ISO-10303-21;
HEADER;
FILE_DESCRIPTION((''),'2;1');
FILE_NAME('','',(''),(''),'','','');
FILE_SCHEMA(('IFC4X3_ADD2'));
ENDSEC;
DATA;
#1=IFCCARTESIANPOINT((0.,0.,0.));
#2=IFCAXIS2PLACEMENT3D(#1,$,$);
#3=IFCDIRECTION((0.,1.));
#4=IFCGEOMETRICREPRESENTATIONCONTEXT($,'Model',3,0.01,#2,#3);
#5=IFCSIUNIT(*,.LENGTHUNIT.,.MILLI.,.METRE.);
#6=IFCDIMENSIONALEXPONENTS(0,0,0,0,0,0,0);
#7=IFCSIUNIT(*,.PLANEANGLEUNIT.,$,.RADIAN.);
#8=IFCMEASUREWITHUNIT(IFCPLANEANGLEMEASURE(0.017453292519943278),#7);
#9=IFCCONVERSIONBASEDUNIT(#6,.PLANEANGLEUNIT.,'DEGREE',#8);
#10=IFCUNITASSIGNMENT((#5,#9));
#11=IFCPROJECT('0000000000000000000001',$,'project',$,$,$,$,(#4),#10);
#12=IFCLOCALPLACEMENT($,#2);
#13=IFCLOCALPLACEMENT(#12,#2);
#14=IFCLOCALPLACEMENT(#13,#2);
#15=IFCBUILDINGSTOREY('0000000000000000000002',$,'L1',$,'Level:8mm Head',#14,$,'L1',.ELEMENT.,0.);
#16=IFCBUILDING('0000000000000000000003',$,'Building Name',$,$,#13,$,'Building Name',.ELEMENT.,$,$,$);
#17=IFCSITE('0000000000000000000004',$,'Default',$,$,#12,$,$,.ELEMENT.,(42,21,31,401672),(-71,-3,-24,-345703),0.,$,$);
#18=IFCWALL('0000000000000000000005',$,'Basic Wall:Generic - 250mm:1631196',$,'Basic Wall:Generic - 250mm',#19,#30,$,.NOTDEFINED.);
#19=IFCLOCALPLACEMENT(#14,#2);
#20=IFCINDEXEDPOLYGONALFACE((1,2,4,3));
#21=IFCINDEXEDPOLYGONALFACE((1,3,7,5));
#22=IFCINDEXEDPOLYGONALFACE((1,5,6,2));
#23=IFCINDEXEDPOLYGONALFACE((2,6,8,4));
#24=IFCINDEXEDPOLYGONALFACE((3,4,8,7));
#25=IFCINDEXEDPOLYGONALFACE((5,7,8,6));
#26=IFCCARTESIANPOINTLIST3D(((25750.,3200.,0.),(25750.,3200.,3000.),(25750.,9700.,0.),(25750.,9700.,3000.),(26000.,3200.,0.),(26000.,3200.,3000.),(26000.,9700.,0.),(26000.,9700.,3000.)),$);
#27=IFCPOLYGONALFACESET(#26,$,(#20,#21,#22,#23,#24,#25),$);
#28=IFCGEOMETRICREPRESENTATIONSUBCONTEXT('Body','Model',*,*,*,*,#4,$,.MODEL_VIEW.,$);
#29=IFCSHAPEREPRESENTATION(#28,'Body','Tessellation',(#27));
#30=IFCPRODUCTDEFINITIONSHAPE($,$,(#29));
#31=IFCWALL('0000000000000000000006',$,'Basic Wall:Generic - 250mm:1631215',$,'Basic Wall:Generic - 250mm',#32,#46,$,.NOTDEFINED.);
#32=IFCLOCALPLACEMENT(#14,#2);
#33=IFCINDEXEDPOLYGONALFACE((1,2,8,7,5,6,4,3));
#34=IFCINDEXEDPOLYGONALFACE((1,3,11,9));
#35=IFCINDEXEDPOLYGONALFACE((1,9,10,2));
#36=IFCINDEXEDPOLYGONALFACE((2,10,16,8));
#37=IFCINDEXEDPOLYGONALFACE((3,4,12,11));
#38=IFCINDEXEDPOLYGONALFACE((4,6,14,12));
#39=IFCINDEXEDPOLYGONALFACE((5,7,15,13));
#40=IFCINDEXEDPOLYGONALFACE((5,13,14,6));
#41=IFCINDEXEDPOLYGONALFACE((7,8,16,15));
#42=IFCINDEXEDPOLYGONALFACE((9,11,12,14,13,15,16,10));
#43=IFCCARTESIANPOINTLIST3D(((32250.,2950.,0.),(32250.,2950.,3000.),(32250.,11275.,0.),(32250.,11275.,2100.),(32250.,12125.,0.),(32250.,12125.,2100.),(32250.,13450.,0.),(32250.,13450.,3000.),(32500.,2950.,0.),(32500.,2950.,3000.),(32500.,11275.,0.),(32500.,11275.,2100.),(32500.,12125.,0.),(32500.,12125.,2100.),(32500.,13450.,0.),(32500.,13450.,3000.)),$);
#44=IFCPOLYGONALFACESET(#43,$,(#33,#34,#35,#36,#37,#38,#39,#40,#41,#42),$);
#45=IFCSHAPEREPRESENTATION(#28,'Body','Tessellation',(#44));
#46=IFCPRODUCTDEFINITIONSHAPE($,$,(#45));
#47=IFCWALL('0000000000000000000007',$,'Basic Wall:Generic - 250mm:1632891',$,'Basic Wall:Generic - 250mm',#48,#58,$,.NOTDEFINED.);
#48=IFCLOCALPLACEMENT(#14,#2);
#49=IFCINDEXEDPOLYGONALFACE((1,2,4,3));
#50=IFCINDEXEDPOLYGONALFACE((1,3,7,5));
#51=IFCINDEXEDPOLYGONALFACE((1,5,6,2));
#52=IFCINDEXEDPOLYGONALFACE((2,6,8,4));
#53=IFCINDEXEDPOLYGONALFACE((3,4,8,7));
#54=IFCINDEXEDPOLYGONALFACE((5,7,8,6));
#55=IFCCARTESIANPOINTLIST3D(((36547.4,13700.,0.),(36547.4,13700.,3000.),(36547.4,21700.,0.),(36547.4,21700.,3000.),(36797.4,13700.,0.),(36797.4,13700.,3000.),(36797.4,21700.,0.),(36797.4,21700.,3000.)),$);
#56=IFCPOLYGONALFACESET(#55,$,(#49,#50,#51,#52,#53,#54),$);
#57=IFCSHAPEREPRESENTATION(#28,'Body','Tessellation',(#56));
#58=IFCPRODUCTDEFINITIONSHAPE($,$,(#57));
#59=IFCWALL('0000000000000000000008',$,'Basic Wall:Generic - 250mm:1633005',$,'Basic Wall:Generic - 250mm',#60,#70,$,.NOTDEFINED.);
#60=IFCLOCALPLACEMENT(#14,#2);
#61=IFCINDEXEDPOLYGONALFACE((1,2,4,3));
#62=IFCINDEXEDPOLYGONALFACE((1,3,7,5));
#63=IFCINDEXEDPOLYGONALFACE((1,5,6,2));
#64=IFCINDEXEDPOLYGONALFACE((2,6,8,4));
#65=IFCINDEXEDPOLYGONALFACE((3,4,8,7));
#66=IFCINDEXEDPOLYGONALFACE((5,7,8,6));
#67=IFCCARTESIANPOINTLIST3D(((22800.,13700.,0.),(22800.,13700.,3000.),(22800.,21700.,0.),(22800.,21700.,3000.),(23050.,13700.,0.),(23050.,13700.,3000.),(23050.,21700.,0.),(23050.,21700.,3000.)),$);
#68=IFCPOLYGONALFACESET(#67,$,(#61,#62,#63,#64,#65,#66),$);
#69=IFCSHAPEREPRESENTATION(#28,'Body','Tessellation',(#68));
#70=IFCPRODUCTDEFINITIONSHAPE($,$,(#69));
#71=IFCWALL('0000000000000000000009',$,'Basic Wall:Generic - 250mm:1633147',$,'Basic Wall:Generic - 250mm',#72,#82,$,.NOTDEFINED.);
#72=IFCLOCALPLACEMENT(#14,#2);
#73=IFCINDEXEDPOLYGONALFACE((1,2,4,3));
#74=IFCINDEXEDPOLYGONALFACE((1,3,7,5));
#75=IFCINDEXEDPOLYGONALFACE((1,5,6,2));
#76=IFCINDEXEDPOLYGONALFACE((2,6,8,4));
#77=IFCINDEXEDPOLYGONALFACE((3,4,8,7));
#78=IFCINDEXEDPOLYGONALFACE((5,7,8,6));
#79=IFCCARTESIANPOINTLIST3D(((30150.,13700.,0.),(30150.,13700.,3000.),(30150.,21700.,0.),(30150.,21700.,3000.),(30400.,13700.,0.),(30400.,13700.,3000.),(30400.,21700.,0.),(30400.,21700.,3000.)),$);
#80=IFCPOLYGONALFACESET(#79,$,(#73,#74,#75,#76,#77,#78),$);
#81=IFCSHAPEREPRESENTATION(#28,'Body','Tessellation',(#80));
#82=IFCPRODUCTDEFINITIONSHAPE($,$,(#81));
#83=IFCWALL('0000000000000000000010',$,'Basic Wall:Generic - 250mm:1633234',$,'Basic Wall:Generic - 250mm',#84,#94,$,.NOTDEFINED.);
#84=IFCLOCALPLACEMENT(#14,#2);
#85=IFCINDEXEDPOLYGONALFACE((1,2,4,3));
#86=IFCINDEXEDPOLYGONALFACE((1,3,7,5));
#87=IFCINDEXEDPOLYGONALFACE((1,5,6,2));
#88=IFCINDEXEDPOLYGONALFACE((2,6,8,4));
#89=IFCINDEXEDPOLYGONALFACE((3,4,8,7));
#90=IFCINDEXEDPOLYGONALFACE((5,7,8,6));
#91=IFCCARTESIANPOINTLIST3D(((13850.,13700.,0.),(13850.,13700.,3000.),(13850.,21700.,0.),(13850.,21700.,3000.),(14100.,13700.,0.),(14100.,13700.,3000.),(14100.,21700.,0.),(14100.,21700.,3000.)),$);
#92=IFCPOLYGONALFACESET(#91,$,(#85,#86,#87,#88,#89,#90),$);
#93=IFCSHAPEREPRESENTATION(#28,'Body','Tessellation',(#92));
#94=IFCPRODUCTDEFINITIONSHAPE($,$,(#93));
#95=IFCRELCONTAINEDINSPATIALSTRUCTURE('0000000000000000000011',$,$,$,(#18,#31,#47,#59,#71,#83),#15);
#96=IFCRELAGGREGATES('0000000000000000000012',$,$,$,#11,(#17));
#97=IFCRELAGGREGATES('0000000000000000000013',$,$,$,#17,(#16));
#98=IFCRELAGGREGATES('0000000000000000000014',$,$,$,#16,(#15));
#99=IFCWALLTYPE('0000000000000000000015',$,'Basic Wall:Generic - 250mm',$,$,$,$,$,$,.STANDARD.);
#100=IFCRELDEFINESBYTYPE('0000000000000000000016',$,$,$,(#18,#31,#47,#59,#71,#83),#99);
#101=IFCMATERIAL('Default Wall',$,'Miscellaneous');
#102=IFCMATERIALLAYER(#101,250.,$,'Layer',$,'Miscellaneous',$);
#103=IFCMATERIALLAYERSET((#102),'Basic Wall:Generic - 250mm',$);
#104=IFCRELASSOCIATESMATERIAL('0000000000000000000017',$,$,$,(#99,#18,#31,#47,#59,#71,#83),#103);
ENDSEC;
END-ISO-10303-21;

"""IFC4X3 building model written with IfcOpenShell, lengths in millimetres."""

from ifc_helpers import new_model, entity, si_unit, converted_unit, direction, frame, frame_2d, origin, place, context, subcontext, project, spatial, rectangle, extrude, material, layer, layer_set, type_object, element, save


model = new_model("IFC4X3")

# Units and contexts
model_context = context("Model", 3, precision=0.01, world=origin(), true_north=direction((0.0, 1.0)))
body_context = subcontext(model_context, "Body", "Model", "MODEL_VIEW")
ifc_project = project(units=[si_unit("LENGTHUNIT", "METRE", prefix="MILLI"), converted_unit("PLANEANGLEUNIT", "DEGREE", entity("IfcPlaneAngleMeasure", 0.017453292519943278), si_unit("PLANEANGLEUNIT", "RADIAN"), dimensions=[0, 0, 0, 0, 0, 0, 0])], contexts=[model_context])

# Site, building, storey
site_placement = place(None, origin())
site = spatial("IfcSite", under=ifc_project, at=site_placement, Name="Default", CompositionType="ELEMENT", RefLatitude=(42, 21, 31, 401672), RefLongitude=(-71, -3, -24, -345703), RefElevation=0.0)
building_placement = place(site_placement, origin())
building = spatial("IfcBuilding", under=site, at=building_placement, Name="Building Name", LongName="Building Name", CompositionType="ELEMENT")
storey_placement = place(building_placement, origin())
storey = spatial("IfcBuildingStorey", under=building, at=storey_placement, Name="L1", ObjectType="Level:8mm Head", LongName="L1", CompositionType="ELEMENT", Elevation=0.0)

# Shared definitions
ifc_material = material(Name="Default Wall", Category="Miscellaneous")
ifc_layer = layer(ifc_material, 250.0, Name="Layer", Category="Miscellaneous")
ifc_layer_set = layer_set([ifc_layer], Name="Basic Wall:Generic - 250mm")
wall_type = type_object("IfcWallType", Name="Basic Wall:Generic - 250mm", PredefinedType="STANDARD", material=ifc_layer_set)

# Wall
wall_1_placement = place(storey_placement, frame((25875.0, 3200.0, 0.0), z_axis=(0.0, 0.0, 1.0), x_axis=(0.0, 1.0, 0.0)))
element("IfcWall", 1, at=wall_1_placement, inside=storey, type_object=wall_type, material=ifc_layer_set, Name="Basic Wall:Generic - 250mm:1631196", ObjectType="Basic Wall:Generic - 250mm", PredefinedType="NOTDEFINED", context=body_context, shape_type="SweptSolid", body=[
    extrude(rectangle(XDim=6500.0, YDim=250.0, at=frame_2d((3250.0, 0.0), x_axis=(-1.0, 0.0))), origin(), (0.0, 0.0, 1.0), 3000.0),
])

# Wall, opening
wall_2_placement = place(storey_placement, frame((32375.0, 2950.0, 0.0), z_axis=(0.0, 0.0, 1.0), x_axis=(0.0, 1.0, 0.0)))
wall_2 = element("IfcWall", 2, at=wall_2_placement, inside=storey, type_object=wall_type, material=ifc_layer_set, Name="Basic Wall:Generic - 250mm:1631215", ObjectType="Basic Wall:Generic - 250mm", PredefinedType="NOTDEFINED", context=body_context, shape_type="SweptSolid", body=[
    extrude(rectangle(XDim=10500.0, YDim=250.0, at=frame_2d((5250.0, 0.0), x_axis=(-1.0, 0.0))), origin(), (0.0, 0.0, 1.0), 3000.0),
])
opening_1_placement = place(wall_2_placement, frame((8325.0, -125.0, 0.0)))
element("IfcOpeningElement", 3, at=opening_1_placement, cuts=wall_2, PredefinedType="OPENING", context=body_context, shape_type="SweptSolid", body=[
    extrude(rectangle(XDim=2100.0, YDim=850.0, at=frame_2d((1050.0, 425.0), x_axis=(1.0, 0.0))), frame((0.0, 0.0, 0.0), z_axis=(0.0, 1.0, 0.0), x_axis=(0.0, 0.0, 1.0)), (0.0, 0.0, 1.0), 250.0),
])

# Walls
wall_3_placement = place(storey_placement, frame((36672.4, 13700.0, 0.0), z_axis=(0.0, 0.0, 1.0), x_axis=(0.0, 1.0, 0.0)))
element("IfcWall", 4, at=wall_3_placement, inside=storey, type_object=wall_type, material=ifc_layer_set, Name="Basic Wall:Generic - 250mm:1632891", ObjectType="Basic Wall:Generic - 250mm", PredefinedType="NOTDEFINED", context=body_context, shape_type="SweptSolid", body=[
    extrude(rectangle(XDim=8000.0, YDim=250.0, at=frame_2d((4000.0, 0.0), x_axis=(-1.0, 0.0))), origin(), (0.0, 0.0, 1.0), 3000.0),
])
for number, where, z_axis, x_axis, name in (
    (5, (22925.0, 21700.0, 0.0), (0.0, 0.0, 1.0), (0.0, -1.0, 0.0), "Basic Wall:Generic - 250mm:1633005"),
    (6, (30275.0, 21700.0, 0.0), (0.0, 0.0, 1.0), (0.0, -1.0, 0.0), "Basic Wall:Generic - 250mm:1633147"),
):
    element("IfcWall", number, at=place(storey_placement, frame(where, z_axis=z_axis, x_axis=x_axis)), inside=storey, type_object=wall_type, material=ifc_layer_set, Name=name, ObjectType="Basic Wall:Generic - 250mm", PredefinedType="NOTDEFINED", context=body_context, shape_type="SweptSolid", body=[
        extrude(rectangle(XDim=8000.0, YDim=250.0, at=frame_2d((4000.0, 0.0), x_axis=(-1.0, 0.0))), origin(), (0.0, 0.0, 1.0), 3000.0),
    ])
wall_4_placement = place(storey_placement, frame((13975.0, 13700.0, 0.0), z_axis=(0.0, 0.0, 1.0), x_axis=(0.0, 1.0, 0.0)))
element("IfcWall", 7, at=wall_4_placement, inside=storey, type_object=wall_type, material=ifc_layer_set, Name="Basic Wall:Generic - 250mm:1633234", ObjectType="Basic Wall:Generic - 250mm", PredefinedType="NOTDEFINED", context=body_context, shape_type="SweptSolid", body=[
    extrude(rectangle(XDim=8000.0, YDim=250.0, at=frame_2d((4000.0, 0.0), x_axis=(-1.0, 0.0))), origin(), (0.0, 0.0, 1.0), 3000.0),
])

save(model, "model.ifc")
